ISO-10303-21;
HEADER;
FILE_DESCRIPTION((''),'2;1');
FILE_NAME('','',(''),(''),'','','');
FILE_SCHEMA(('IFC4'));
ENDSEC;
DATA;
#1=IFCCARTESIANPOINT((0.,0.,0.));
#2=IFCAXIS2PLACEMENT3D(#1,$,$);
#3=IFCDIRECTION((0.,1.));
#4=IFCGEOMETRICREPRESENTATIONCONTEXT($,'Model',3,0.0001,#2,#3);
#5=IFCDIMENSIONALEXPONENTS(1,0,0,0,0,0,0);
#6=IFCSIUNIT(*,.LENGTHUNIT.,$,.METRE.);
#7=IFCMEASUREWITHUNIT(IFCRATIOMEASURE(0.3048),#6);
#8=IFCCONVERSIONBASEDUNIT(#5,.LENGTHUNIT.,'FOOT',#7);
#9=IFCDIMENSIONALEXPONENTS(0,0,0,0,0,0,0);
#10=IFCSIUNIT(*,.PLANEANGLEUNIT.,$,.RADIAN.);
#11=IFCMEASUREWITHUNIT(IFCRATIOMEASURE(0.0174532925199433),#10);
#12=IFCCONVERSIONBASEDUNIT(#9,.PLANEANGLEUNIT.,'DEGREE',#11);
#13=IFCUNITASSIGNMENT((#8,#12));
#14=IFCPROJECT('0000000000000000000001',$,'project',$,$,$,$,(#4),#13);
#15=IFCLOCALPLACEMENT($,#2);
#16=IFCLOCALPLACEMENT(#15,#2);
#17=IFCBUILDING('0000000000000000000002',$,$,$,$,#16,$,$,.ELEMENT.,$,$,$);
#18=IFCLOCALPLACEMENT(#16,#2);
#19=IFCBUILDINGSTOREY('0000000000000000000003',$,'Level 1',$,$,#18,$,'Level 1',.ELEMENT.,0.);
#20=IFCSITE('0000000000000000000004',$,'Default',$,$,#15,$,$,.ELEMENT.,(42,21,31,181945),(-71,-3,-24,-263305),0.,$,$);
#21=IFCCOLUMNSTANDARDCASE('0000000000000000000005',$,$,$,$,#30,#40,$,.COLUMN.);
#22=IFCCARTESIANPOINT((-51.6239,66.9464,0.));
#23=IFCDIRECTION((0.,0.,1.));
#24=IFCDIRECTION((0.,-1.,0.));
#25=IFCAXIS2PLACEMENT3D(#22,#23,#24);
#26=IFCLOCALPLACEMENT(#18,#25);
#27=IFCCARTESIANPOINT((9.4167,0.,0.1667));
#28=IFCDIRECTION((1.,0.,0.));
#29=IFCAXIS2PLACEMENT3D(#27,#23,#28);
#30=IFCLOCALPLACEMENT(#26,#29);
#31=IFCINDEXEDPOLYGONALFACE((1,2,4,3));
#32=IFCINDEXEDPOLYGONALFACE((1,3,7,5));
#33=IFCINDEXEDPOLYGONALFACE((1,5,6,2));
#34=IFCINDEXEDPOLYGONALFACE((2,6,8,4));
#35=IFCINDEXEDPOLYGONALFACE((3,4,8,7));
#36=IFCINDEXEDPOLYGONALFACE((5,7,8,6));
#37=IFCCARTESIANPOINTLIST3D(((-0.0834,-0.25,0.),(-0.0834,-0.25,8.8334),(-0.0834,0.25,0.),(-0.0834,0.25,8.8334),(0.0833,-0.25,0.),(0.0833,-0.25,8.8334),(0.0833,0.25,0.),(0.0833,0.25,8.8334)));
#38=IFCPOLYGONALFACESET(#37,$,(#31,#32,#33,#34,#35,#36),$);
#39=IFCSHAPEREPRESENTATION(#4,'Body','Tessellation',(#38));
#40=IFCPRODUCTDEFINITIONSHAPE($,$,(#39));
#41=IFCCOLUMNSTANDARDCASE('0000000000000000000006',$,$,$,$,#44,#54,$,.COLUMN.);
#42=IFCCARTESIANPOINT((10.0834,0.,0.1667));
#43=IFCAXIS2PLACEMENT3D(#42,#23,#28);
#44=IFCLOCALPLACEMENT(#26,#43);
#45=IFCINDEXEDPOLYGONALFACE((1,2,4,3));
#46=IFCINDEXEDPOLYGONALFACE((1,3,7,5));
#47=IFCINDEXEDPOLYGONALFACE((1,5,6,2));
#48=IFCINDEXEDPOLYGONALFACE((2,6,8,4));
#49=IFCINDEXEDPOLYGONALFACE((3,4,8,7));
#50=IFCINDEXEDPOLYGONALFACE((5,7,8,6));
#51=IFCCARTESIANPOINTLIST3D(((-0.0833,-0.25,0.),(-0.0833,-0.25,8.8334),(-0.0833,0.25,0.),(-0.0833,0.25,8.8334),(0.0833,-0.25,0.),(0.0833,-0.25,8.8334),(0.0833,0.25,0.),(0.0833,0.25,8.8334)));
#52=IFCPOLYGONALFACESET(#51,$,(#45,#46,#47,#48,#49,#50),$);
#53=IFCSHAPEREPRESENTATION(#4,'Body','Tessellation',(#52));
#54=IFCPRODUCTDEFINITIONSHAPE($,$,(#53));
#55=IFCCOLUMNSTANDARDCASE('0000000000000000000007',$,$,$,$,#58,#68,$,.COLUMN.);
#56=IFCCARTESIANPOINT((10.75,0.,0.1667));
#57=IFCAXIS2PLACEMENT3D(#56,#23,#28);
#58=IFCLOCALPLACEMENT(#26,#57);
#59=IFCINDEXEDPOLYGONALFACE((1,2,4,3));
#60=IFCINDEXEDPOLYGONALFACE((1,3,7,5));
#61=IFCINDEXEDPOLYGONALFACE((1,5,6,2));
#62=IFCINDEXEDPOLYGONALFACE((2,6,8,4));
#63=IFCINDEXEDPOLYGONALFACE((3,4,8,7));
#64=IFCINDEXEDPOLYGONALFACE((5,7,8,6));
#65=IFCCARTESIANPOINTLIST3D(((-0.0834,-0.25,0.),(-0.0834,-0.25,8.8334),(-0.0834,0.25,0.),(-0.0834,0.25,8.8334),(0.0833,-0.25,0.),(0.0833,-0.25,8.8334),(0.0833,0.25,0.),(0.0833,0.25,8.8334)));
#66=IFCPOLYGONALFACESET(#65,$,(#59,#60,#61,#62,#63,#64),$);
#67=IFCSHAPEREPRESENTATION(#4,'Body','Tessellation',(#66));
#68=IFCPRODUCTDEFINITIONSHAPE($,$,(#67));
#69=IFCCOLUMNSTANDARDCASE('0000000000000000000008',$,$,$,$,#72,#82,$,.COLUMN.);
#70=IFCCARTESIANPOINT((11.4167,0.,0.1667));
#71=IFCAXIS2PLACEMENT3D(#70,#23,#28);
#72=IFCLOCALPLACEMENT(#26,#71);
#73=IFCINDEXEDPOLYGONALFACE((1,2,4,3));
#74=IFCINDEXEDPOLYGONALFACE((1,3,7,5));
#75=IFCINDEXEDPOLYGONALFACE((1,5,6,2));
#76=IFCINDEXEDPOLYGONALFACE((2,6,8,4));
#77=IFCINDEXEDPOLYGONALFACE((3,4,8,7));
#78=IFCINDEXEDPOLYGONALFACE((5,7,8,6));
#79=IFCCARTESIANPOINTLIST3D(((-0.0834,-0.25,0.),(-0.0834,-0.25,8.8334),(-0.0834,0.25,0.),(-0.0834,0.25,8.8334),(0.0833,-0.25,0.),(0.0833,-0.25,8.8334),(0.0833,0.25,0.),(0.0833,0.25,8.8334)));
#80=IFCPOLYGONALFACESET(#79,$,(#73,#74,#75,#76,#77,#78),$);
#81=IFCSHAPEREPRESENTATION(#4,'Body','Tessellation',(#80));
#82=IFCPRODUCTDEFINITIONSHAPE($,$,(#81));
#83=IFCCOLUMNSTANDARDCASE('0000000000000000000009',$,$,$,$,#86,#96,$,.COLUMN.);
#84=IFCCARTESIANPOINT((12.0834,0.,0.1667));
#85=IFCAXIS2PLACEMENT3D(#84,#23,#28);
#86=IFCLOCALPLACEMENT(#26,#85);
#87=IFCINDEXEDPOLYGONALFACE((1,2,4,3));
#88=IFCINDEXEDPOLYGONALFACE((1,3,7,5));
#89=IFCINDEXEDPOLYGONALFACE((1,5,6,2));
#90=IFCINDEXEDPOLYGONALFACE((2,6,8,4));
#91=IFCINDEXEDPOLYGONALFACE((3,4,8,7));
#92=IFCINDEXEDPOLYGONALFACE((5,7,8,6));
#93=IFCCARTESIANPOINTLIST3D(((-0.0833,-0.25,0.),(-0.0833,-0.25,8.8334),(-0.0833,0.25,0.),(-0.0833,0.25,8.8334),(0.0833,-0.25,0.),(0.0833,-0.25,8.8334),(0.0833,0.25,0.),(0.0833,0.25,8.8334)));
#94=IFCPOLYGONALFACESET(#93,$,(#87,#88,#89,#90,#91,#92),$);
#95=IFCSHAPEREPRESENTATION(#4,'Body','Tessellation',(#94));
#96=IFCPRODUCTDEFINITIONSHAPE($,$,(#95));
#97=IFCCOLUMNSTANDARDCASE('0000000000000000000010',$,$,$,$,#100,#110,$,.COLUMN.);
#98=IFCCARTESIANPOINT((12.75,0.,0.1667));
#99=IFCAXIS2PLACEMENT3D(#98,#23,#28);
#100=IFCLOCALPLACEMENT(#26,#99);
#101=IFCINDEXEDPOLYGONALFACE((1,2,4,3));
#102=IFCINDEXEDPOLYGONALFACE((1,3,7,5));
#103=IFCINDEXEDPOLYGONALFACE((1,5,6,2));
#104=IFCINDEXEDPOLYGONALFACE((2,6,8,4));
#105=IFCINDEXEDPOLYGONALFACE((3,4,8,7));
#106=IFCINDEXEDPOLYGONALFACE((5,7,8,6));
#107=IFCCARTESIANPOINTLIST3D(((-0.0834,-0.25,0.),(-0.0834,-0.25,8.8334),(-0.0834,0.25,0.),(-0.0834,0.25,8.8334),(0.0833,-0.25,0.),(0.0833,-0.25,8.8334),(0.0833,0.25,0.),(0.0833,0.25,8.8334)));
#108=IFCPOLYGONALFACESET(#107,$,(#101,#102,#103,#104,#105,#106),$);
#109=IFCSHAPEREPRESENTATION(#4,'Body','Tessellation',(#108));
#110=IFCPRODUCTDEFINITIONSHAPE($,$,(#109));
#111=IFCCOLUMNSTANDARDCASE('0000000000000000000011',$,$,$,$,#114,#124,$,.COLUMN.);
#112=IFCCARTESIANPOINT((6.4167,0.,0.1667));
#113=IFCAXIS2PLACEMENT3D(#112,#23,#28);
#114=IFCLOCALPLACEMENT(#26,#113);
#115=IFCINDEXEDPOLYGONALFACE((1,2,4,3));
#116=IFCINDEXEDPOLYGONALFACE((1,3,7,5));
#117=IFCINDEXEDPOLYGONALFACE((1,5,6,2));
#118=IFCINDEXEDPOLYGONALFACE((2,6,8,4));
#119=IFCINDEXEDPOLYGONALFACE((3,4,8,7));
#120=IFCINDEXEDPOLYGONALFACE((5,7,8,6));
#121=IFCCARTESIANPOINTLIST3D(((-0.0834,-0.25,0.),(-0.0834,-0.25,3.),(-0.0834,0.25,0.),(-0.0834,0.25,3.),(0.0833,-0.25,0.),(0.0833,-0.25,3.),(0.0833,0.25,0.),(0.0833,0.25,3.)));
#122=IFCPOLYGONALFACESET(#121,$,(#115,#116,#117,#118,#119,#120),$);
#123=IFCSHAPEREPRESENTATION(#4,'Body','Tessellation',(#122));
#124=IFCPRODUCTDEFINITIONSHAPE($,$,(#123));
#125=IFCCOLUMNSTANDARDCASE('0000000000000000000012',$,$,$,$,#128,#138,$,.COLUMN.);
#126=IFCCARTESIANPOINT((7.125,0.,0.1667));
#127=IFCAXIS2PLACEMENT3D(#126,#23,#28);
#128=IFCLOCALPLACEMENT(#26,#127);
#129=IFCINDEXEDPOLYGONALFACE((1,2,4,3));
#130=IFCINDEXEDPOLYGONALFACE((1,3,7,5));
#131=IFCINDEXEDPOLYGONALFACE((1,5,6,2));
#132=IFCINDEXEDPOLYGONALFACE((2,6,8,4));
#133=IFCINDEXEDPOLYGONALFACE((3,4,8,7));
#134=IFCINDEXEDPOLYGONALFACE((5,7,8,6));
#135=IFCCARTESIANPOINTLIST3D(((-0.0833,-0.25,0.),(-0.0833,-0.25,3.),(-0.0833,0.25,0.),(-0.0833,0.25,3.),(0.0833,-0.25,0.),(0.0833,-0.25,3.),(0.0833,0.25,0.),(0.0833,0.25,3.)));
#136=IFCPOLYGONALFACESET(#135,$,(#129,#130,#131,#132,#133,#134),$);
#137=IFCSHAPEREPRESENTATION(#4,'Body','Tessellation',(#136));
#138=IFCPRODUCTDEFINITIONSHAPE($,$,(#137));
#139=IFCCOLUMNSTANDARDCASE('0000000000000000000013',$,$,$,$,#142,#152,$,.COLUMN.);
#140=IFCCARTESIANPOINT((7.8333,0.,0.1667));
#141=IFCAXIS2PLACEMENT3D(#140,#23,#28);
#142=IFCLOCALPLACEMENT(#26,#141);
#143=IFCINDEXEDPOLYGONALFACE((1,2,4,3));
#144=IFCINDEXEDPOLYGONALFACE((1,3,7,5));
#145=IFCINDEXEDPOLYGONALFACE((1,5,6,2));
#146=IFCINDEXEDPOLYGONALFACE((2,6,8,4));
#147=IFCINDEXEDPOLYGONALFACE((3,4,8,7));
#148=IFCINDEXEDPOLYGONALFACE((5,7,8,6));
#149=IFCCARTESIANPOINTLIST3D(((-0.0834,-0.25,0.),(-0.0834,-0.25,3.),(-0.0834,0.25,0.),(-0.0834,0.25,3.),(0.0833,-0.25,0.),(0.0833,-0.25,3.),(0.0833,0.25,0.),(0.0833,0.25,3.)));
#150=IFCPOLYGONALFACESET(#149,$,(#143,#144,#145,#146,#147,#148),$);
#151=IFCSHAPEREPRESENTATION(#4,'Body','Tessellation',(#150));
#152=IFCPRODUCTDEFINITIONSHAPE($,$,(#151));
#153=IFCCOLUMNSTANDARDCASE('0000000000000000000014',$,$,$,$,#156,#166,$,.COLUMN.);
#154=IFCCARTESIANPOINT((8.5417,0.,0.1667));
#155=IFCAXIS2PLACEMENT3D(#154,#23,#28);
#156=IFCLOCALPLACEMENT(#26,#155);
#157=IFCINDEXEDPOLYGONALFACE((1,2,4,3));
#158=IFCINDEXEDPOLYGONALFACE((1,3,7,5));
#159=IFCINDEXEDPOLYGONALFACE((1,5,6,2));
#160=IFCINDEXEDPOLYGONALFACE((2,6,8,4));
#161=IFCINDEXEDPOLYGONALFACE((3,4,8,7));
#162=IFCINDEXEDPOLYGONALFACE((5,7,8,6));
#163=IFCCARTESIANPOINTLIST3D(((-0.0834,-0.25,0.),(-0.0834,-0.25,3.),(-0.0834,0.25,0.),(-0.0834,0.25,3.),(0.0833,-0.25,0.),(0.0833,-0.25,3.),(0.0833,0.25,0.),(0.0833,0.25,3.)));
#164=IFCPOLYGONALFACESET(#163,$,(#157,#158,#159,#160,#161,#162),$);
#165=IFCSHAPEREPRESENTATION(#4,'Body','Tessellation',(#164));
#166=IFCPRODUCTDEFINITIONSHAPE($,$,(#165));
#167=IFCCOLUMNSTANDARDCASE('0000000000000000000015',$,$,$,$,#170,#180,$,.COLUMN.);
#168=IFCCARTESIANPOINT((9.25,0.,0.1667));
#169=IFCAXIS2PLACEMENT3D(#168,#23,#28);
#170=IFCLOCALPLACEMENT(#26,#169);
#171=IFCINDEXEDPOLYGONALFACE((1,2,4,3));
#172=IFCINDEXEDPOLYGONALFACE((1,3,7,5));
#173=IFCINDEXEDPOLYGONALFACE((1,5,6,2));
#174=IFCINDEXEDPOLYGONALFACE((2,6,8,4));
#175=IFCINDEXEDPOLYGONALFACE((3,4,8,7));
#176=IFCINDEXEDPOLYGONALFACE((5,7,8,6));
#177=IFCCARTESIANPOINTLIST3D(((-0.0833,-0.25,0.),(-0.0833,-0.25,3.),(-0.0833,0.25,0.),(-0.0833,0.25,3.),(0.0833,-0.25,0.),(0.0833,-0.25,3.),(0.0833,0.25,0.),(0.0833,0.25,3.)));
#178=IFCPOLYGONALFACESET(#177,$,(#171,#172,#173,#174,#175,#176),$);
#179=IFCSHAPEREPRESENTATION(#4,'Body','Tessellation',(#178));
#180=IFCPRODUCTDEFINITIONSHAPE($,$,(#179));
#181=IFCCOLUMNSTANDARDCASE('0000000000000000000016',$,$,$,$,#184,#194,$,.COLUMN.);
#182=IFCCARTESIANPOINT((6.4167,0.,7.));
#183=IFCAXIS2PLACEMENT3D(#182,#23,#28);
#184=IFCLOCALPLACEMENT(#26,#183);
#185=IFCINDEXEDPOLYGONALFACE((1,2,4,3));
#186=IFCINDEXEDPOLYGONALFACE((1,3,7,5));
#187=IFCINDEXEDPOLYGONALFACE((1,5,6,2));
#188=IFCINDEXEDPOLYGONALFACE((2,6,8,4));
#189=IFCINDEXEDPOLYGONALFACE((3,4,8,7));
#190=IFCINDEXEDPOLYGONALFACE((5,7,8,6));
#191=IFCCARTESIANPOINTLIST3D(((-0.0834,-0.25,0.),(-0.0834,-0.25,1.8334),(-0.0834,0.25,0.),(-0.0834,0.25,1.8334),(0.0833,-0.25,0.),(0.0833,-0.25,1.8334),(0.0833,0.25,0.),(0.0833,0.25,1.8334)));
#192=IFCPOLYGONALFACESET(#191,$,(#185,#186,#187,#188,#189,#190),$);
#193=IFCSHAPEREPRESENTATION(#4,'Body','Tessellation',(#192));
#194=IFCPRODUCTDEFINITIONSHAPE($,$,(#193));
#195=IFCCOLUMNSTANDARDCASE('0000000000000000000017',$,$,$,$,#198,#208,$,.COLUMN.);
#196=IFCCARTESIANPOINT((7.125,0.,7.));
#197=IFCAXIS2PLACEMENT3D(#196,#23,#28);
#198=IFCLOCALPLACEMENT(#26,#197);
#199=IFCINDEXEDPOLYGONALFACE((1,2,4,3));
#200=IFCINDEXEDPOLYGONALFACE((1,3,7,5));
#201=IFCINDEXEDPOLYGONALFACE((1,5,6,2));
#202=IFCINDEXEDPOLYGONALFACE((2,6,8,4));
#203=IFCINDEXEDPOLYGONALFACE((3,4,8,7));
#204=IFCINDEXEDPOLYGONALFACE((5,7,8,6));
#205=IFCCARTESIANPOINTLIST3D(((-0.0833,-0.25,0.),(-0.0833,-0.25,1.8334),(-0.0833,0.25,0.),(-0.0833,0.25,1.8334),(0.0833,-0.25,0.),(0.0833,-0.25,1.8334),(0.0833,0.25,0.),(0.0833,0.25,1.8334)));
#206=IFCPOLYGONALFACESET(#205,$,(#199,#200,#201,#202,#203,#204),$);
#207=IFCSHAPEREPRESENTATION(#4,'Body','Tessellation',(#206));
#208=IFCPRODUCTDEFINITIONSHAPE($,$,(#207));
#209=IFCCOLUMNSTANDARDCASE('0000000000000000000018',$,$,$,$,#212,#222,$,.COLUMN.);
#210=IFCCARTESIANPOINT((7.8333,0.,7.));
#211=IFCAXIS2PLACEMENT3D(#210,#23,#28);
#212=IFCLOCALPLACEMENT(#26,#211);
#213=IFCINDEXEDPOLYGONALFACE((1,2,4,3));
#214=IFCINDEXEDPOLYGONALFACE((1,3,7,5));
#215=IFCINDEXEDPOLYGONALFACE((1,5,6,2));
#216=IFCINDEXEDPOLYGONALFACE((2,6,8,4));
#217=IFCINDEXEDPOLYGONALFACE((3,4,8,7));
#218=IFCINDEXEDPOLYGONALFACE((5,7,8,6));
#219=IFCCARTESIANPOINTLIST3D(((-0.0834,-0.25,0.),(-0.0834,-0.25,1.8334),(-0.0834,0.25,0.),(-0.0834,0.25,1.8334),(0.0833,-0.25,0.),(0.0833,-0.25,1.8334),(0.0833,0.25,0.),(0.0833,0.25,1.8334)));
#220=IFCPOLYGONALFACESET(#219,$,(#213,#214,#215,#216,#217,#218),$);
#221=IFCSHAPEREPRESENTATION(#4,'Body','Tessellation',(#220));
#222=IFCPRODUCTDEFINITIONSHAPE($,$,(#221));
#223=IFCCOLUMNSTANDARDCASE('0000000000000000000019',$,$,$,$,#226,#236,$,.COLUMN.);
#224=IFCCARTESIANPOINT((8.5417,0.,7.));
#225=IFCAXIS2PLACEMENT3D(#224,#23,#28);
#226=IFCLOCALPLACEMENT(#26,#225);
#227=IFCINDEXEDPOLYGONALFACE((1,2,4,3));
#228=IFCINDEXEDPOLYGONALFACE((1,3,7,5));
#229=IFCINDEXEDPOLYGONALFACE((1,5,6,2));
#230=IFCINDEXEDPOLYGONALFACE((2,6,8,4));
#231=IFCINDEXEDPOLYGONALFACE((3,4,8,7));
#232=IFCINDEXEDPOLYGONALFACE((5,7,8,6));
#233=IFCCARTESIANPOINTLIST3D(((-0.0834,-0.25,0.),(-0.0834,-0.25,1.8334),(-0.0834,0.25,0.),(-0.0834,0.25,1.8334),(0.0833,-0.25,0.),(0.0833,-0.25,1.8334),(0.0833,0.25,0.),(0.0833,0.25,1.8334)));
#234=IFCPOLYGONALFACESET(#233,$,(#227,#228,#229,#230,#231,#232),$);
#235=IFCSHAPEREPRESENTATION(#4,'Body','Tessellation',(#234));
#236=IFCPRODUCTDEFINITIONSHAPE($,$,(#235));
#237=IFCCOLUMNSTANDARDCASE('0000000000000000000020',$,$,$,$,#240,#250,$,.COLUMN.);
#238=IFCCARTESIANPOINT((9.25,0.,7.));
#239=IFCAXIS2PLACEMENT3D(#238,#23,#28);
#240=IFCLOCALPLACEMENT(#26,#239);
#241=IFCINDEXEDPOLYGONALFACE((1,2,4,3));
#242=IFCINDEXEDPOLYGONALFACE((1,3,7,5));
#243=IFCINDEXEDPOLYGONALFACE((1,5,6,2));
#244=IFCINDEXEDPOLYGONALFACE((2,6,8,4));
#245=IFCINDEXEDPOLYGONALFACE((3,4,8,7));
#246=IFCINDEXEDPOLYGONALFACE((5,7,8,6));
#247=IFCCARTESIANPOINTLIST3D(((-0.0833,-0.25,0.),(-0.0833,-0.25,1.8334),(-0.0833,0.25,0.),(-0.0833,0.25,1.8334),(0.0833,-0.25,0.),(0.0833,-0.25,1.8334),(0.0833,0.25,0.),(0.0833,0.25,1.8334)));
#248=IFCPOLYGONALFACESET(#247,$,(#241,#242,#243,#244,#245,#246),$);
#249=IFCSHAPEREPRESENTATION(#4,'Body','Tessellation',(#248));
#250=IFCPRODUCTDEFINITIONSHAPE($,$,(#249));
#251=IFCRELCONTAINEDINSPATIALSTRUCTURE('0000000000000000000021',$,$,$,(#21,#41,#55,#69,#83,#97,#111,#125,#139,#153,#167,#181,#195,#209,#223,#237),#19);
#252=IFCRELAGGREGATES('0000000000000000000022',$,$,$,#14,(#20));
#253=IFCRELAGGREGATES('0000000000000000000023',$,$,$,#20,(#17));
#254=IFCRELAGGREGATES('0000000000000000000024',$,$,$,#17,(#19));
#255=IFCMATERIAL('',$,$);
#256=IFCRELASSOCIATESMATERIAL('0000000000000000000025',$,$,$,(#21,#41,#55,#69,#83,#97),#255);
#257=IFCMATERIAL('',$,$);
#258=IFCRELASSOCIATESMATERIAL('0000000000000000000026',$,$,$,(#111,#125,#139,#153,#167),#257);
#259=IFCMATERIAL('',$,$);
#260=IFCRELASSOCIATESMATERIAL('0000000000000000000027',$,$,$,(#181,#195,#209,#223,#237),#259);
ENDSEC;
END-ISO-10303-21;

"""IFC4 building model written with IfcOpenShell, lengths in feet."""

from ifc_helpers import new_model, entity, si_unit, converted_unit, direction, frame, origin, place, context, project, spatial, rectangle, extrude, material, element, save


model = new_model("IFC4")

# Units and contexts
model_context = context("Model", 3, precision=0.0001, world=origin(), true_north=direction((0.0, 1.0)))
ifc_project = project(units=[converted_unit("LENGTHUNIT", "FOOT", entity("IfcRatioMeasure", 0.3048), si_unit("LENGTHUNIT", "METRE"), dimensions=[1, 0, 0, 0, 0, 0, 0]), converted_unit("PLANEANGLEUNIT", "DEGREE", entity("IfcRatioMeasure", 0.0174532925199433), si_unit("PLANEANGLEUNIT", "RADIAN"), dimensions=[0, 0, 0, 0, 0, 0, 0])], contexts=[model_context])

# Site, building, storey
site_placement = place(None, origin())
site = spatial("IfcSite", under=ifc_project, at=site_placement, Name="Default", CompositionType="ELEMENT", RefLatitude=(42, 21, 31, 181945), RefLongitude=(-71, -3, -24, -263305), RefElevation=0.0)
building_placement = place(site_placement, origin())
building = spatial("IfcBuilding", under=site, at=building_placement, CompositionType="ELEMENT")
storey_placement = place(building_placement, origin())
storey = spatial("IfcBuildingStorey", under=building, at=storey_placement, Name="Level 1", LongName="Level 1", CompositionType="ELEMENT", Elevation=0.0)

# Columns
ifc_material_1 = material(Name="")
placement_1 = place(storey_placement, frame((-51.6239, 66.9464, 0.0), z_axis=(0.0, 0.0, 1.0), x_axis=(0.0, -1.0, 0.0)))
for number, where, z_axis, x_axis in (
    (1, (9.4167, 0.0, 0.1667), (0.0, 0.0, 1.0), (1.0, 0.0, 0.0)),
    (2, (10.0834, 0.0, 0.1667), (0.0, 0.0, 1.0), (1.0, 0.0, 0.0)),
    (3, (10.75, 0.0, 0.1667), (0.0, 0.0, 1.0), (1.0, 0.0, 0.0)),
    (4, (11.4167, 0.0, 0.1667), (0.0, 0.0, 1.0), (1.0, 0.0, 0.0)),
    (5, (12.0834, 0.0, 0.1667), (0.0, 0.0, 1.0), (1.0, 0.0, 0.0)),
    (6, (12.75, 0.0, 0.1667), (0.0, 0.0, 1.0), (1.0, 0.0, 0.0)),
):
    element("IfcColumnStandardCase", number, at=place(placement_1, frame(where, z_axis=z_axis, x_axis=x_axis)), inside=storey, material=ifc_material_1, PredefinedType="COLUMN", context=model_context, shape_type="SweptSolid", body=[
        extrude(rectangle(XDim=0.1667, YDim=0.5), origin(), (0.0, 0.0, 1.0), 8.8334),
    ])
ifc_material_2 = material(Name="")
for number, where, z_axis, x_axis in (
    (7, (6.4167, 0.0, 0.1667), (0.0, 0.0, 1.0), (1.0, 0.0, 0.0)),
    (8, (7.125, 0.0, 0.1667), (0.0, 0.0, 1.0), (1.0, 0.0, 0.0)),
    (9, (7.8333, 0.0, 0.1667), (0.0, 0.0, 1.0), (1.0, 0.0, 0.0)),
    (10, (8.5417, 0.0, 0.1667), (0.0, 0.0, 1.0), (1.0, 0.0, 0.0)),
    (11, (9.25, 0.0, 0.1667), (0.0, 0.0, 1.0), (1.0, 0.0, 0.0)),
):
    element("IfcColumnStandardCase", number, at=place(placement_1, frame(where, z_axis=z_axis, x_axis=x_axis)), inside=storey, material=ifc_material_2, PredefinedType="COLUMN", context=model_context, shape_type="SweptSolid", body=[
        extrude(rectangle(XDim=0.1667, YDim=0.5), origin(), (0.0, 0.0, 1.0), 3.0),
    ])
ifc_material_3 = material(Name="")
for number, where, z_axis, x_axis in (
    (12, (6.4167, 0.0, 7.0), (0.0, 0.0, 1.0), (1.0, 0.0, 0.0)),
    (13, (7.125, 0.0, 7.0), (0.0, 0.0, 1.0), (1.0, 0.0, 0.0)),
    (14, (7.8333, 0.0, 7.0), (0.0, 0.0, 1.0), (1.0, 0.0, 0.0)),
    (15, (8.5417, 0.0, 7.0), (0.0, 0.0, 1.0), (1.0, 0.0, 0.0)),
    (16, (9.25, 0.0, 7.0), (0.0, 0.0, 1.0), (1.0, 0.0, 0.0)),
):
    element("IfcColumnStandardCase", number, at=place(placement_1, frame(where, z_axis=z_axis, x_axis=x_axis)), inside=storey, material=ifc_material_3, PredefinedType="COLUMN", context=model_context, shape_type="SweptSolid", body=[
        extrude(rectangle(XDim=0.1667, YDim=0.5), origin(), (0.0, 0.0, 1.0), 1.8334),
    ])

save(model, "model.ifc")
